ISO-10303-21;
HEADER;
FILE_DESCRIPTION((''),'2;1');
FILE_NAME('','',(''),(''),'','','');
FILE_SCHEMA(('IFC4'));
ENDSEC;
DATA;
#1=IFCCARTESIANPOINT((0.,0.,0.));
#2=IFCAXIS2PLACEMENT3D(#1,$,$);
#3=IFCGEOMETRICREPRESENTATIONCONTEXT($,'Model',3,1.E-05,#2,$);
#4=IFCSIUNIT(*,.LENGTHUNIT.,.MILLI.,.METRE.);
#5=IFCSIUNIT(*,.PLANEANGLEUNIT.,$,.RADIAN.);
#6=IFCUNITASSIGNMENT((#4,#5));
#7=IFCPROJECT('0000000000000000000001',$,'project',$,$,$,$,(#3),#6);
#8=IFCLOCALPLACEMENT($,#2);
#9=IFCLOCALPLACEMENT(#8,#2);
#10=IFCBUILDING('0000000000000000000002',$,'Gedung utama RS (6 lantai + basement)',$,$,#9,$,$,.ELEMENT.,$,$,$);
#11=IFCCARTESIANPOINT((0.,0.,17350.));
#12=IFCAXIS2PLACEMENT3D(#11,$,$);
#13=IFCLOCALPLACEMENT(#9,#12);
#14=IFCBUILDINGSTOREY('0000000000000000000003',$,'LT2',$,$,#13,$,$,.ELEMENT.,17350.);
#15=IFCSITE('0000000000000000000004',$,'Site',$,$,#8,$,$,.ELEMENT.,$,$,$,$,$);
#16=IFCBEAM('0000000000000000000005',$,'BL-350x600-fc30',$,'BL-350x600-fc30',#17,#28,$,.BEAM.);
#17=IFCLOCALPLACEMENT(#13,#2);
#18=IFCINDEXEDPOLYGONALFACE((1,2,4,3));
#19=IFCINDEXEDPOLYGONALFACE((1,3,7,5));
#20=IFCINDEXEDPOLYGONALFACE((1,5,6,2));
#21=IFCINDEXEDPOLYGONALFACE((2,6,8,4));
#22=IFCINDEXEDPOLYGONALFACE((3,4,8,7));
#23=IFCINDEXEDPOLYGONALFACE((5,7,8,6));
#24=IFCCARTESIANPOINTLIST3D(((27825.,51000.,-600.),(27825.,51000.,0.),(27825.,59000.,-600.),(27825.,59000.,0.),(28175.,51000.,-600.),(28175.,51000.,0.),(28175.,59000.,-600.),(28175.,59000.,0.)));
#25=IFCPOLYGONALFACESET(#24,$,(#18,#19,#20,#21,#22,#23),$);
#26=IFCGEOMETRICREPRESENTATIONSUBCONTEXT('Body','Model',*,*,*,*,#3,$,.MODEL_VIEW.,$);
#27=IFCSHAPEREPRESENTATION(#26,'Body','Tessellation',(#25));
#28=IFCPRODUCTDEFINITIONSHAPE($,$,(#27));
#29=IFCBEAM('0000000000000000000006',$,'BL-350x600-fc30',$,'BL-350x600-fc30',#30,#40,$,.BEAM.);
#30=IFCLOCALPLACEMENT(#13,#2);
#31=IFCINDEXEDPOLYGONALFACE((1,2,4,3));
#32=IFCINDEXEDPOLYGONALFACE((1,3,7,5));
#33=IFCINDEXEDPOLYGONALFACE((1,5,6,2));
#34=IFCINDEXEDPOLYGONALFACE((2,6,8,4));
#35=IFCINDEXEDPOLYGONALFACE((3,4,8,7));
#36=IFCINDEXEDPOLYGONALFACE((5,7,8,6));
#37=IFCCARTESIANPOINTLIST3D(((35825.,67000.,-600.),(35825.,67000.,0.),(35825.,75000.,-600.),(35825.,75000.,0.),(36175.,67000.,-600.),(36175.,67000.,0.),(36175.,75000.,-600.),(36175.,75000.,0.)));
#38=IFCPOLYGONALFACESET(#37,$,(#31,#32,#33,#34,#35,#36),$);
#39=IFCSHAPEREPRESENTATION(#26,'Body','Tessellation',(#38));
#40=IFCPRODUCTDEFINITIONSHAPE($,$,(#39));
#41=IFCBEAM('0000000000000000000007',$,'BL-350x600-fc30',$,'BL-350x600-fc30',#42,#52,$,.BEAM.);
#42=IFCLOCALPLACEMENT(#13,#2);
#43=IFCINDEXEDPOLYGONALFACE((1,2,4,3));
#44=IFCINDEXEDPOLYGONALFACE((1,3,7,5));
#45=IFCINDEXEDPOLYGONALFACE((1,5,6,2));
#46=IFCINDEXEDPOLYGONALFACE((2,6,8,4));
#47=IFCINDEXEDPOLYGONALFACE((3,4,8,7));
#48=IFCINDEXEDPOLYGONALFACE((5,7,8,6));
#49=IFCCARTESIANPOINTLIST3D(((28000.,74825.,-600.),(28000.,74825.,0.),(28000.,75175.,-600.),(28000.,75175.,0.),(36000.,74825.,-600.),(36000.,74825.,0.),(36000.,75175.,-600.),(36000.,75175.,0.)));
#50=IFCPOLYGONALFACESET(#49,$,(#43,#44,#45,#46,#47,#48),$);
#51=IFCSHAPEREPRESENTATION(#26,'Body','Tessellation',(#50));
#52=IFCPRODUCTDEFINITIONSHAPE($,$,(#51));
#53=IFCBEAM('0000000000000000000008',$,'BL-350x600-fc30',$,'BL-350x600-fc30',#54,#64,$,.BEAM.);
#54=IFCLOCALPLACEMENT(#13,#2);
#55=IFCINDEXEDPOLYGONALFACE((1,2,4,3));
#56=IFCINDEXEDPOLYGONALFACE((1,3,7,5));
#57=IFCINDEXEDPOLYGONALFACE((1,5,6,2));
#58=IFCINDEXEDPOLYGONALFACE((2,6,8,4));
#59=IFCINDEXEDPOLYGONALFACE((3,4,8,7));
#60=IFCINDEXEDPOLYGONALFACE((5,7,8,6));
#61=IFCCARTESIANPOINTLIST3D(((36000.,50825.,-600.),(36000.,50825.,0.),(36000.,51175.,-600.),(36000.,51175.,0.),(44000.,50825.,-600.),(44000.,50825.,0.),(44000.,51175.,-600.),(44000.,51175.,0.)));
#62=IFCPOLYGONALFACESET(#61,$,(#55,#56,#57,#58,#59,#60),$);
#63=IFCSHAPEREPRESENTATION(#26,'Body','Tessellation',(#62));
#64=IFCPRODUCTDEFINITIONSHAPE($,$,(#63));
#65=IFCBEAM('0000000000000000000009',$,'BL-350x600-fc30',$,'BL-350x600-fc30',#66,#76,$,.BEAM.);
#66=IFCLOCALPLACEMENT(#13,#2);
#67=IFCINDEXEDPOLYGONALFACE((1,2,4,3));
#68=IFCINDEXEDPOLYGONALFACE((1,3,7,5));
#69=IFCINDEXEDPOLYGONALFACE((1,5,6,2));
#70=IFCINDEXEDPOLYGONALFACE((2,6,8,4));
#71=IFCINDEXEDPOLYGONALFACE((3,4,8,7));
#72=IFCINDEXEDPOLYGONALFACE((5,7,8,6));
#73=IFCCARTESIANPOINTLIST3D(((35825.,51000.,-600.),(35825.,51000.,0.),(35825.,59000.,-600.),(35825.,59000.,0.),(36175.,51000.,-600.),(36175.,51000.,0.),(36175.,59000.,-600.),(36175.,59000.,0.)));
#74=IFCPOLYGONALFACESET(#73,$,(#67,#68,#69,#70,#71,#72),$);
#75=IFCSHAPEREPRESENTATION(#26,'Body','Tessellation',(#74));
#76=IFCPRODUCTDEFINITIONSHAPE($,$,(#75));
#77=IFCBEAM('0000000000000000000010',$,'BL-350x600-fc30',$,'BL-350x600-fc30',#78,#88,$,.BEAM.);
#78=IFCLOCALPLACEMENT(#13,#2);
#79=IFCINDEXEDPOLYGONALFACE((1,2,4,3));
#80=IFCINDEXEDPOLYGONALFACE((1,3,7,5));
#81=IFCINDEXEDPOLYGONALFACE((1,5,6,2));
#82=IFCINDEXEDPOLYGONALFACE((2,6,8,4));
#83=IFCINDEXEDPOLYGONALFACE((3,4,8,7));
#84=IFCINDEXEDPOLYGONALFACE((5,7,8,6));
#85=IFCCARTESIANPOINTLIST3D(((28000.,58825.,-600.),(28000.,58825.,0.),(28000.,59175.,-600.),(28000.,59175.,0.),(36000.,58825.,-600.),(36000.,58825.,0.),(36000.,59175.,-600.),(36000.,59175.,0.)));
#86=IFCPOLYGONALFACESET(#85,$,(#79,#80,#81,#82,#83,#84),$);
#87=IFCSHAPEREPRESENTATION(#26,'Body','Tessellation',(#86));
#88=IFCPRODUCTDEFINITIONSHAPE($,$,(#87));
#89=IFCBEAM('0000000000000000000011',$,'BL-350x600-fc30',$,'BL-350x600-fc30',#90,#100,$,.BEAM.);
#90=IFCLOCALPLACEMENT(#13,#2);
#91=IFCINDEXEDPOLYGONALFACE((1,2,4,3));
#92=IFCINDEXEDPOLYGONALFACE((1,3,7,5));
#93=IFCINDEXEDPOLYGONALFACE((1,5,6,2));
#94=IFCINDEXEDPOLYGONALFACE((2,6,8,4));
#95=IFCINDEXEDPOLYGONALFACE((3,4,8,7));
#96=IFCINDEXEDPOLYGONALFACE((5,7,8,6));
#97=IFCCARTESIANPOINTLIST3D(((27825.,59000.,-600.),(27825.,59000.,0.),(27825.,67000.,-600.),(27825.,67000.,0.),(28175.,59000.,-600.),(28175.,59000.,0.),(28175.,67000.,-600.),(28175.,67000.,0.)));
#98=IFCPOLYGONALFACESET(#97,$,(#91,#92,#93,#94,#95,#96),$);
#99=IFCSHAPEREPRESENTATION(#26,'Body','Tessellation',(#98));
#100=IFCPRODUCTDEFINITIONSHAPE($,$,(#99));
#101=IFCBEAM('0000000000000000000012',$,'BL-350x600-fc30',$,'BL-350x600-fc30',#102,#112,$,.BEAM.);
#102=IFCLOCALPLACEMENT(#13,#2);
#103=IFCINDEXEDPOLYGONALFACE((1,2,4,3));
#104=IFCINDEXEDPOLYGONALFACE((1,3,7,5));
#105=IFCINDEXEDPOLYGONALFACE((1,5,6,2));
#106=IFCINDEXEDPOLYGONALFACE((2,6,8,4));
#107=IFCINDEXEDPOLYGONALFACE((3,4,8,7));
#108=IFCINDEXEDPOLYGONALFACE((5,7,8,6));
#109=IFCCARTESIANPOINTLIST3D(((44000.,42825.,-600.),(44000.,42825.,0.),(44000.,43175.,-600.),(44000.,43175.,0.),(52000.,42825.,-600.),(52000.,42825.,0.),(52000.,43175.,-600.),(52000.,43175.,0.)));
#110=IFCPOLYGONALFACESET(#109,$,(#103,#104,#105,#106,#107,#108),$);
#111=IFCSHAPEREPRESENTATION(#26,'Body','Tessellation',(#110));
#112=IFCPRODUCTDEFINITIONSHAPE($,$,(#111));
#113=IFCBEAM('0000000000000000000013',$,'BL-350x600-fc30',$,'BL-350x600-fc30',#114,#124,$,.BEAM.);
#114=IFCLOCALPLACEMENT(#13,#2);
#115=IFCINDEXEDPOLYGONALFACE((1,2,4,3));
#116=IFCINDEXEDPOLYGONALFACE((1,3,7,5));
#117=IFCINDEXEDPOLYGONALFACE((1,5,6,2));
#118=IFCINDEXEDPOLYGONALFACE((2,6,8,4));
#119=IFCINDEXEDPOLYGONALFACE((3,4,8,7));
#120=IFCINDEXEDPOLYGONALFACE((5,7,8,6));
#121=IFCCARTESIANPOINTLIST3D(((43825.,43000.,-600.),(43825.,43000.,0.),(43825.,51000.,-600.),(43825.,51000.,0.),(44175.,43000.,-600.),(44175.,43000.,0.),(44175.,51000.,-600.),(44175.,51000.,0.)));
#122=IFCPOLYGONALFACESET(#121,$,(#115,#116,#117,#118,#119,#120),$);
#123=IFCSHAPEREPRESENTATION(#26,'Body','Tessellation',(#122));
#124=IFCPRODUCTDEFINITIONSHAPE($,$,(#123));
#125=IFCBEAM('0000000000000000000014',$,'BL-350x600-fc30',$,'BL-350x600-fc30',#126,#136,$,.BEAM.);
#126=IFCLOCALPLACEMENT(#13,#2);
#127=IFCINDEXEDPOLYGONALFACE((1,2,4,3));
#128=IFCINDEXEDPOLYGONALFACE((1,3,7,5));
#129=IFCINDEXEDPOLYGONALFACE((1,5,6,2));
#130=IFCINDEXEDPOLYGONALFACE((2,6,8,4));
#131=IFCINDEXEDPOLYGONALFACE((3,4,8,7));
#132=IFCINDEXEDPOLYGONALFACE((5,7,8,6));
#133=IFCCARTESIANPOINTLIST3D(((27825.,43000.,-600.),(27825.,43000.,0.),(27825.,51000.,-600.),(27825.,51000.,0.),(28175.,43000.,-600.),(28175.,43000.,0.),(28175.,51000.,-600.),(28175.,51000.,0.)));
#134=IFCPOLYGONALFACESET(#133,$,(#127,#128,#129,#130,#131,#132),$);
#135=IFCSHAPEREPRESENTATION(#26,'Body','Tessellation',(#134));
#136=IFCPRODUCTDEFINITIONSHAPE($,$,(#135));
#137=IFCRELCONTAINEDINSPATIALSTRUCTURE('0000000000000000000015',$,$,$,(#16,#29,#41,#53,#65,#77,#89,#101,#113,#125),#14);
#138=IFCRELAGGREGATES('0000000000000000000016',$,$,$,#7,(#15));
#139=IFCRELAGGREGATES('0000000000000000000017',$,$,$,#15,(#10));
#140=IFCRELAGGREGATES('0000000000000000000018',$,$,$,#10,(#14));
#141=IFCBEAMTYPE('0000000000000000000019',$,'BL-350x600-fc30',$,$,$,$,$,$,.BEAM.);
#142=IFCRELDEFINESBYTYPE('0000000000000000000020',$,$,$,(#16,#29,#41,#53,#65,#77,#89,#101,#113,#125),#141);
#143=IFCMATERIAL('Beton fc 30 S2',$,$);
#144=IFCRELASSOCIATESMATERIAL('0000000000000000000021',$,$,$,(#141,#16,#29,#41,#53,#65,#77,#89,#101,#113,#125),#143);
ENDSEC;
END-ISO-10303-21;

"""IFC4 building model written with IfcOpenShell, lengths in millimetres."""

from ifc_helpers import new_model, si_unit, frame, origin, origin_2d, place, context, subcontext, project, spatial, rectangle, extrude, material, material_profile, profile_set, profile_usage, type_object, element, save


model = new_model("IFC4")

# Units and contexts
model_context = context("Model", 3, precision=1e-05, world=origin())
body_context = subcontext(model_context, "Body", "Model", "MODEL_VIEW")
ifc_project = project(units=[si_unit("LENGTHUNIT", "METRE", prefix="MILLI"), si_unit("PLANEANGLEUNIT", "RADIAN")], contexts=[model_context])

# Site, building, storey
site_placement = place(None, origin())
site = spatial("IfcSite", under=ifc_project, at=site_placement, Name="Site", CompositionType="ELEMENT")
building_placement = place(site_placement, origin())
building = spatial("IfcBuilding", under=site, at=building_placement, Name="Gedung utama RS (6 lantai + basement)", CompositionType="ELEMENT")
storey_placement = place(building_placement, frame((0.0, 0.0, 17350.0)))
storey = spatial("IfcBuildingStorey", under=building, at=storey_placement, Name="LT2", CompositionType="ELEMENT", Elevation=17350.0)

# Beams
ifc_material = material(Name="Beton fc 30 S2")
ifc_material_profile_1 = material_profile(ifc_material, rectangle(XDim=350.0, YDim=600.0, at=origin_2d()), Name="BL-350x600-fc30")
ifc_profile_set_1 = profile_set([ifc_material_profile_1], Name="BL-350x600-fc30")
ifc_profile_usage_1 = profile_usage(ifc_profile_set_1, cardinal=8)
beam_type = type_object("IfcBeamType", Name="BL-350x600-fc30", PredefinedType="BEAM", material=ifc_profile_set_1)
for number, where, name in (
    (1, (28000.0, 51000.0, -300.0), "BL-350x600-fc30"),
    (2, (36000.0, 67000.0, -300.0), "BL-350x600-fc30"),
):
    element("IfcBeam", number, at=place(storey_placement, frame(where)), inside=storey, type_object=beam_type, material=ifc_profile_usage_1, Name=name, ObjectType="BL-350x600-fc30", PredefinedType="BEAM", context=body_context, shape_type="SweptSolid", body=[
        extrude(rectangle(XDim=350.0, YDim=600.0, at=origin_2d()), frame((0.0, 0.0, 0.0), z_axis=(0.0, 1.0, 0.0), x_axis=(-1.0, 0.0, 0.0)), (0.0, 0.0, 1.0), 8000.0),
    ])
for number, where, name in (
    (3, (28000.0, 75000.0, -300.0), "BL-350x600-fc30"),
    (4, (36000.0, 51000.0, -300.0), "BL-350x600-fc30"),
):
    element("IfcBeam", number, at=place(storey_placement, frame(where)), inside=storey, type_object=beam_type, material=ifc_profile_usage_1, Name=name, ObjectType="BL-350x600-fc30", PredefinedType="BEAM", context=body_context, shape_type="SweptSolid", body=[
        extrude(rectangle(XDim=350.0, YDim=600.0, at=origin_2d()), frame((0.0, 0.0, 0.0), z_axis=(1.0, 0.0, 0.0), x_axis=(0.0, 1.0, 0.0)), (0.0, 0.0, 1.0), 8000.0),
    ])
beam_1_placement = place(storey_placement, frame((36000.0, 51000.0, -300.0)))
element("IfcBeam", 5, at=beam_1_placement, inside=storey, type_object=beam_type, material=ifc_profile_usage_1, Name="BL-350x600-fc30", ObjectType="BL-350x600-fc30", PredefinedType="BEAM", context=body_context, shape_type="SweptSolid", body=[
    extrude(rectangle(XDim=350.0, YDim=600.0, at=origin_2d()), frame((0.0, 0.0, 0.0), z_axis=(0.0, 1.0, 0.0), x_axis=(-1.0, 0.0, 0.0)), (0.0, 0.0, 1.0), 8000.0),
])
beam_2_placement = place(storey_placement, frame((28000.0, 59000.0, -300.0)))
element("IfcBeam", 6, at=beam_2_placement, inside=storey, type_object=beam_type, material=ifc_profile_usage_1, Name="BL-350x600-fc30", ObjectType="BL-350x600-fc30", PredefinedType="BEAM", context=body_context, shape_type="SweptSolid", body=[
    extrude(rectangle(XDim=350.0, YDim=600.0, at=origin_2d()), frame((0.0, 0.0, 0.0), z_axis=(1.0, 0.0, 0.0), x_axis=(0.0, 1.0, 0.0)), (0.0, 0.0, 1.0), 8000.0),
])
beam_3_placement = place(storey_placement, frame((28000.0, 59000.0, -300.0)))
element("IfcBeam", 7, at=beam_3_placement, inside=storey, type_object=beam_type, material=ifc_profile_usage_1, Name="BL-350x600-fc30", ObjectType="BL-350x600-fc30", PredefinedType="BEAM", context=body_context, shape_type="SweptSolid", body=[
    extrude(rectangle(XDim=350.0, YDim=600.0, at=origin_2d()), frame((0.0, 0.0, 0.0), z_axis=(0.0, 1.0, 0.0), x_axis=(-1.0, 0.0, 0.0)), (0.0, 0.0, 1.0), 8000.0),
])
beam_4_placement = place(storey_placement, frame((44000.0, 43000.0, -300.0)))
element("IfcBeam", 8, at=beam_4_placement, inside=storey, type_object=beam_type, material=ifc_profile_usage_1, Name="BL-350x600-fc30", ObjectType="BL-350x600-fc30", PredefinedType="BEAM", context=body_context, shape_type="SweptSolid", body=[
    extrude(rectangle(XDim=350.0, YDim=600.0, at=origin_2d()), frame((0.0, 0.0, 0.0), z_axis=(1.0, 0.0, 0.0), x_axis=(0.0, 1.0, 0.0)), (0.0, 0.0, 1.0), 8000.0),
])
for number, where, name in (
    (9, (44000.0, 43000.0, -300.0), "BL-350x600-fc30"),
    (10, (28000.0, 43000.0, -300.0), "BL-350x600-fc30"),
):
    element("IfcBeam", number, at=place(storey_placement, frame(where)), inside=storey, type_object=beam_type, material=ifc_profile_usage_1, Name=name, ObjectType="BL-350x600-fc30", PredefinedType="BEAM", context=body_context, shape_type="SweptSolid", body=[
        extrude(rectangle(XDim=350.0, YDim=600.0, at=origin_2d()), frame((0.0, 0.0, 0.0), z_axis=(0.0, 1.0, 0.0), x_axis=(-1.0, 0.0, 0.0)), (0.0, 0.0, 1.0), 8000.0),
    ])

save(model, "model.ifc")
